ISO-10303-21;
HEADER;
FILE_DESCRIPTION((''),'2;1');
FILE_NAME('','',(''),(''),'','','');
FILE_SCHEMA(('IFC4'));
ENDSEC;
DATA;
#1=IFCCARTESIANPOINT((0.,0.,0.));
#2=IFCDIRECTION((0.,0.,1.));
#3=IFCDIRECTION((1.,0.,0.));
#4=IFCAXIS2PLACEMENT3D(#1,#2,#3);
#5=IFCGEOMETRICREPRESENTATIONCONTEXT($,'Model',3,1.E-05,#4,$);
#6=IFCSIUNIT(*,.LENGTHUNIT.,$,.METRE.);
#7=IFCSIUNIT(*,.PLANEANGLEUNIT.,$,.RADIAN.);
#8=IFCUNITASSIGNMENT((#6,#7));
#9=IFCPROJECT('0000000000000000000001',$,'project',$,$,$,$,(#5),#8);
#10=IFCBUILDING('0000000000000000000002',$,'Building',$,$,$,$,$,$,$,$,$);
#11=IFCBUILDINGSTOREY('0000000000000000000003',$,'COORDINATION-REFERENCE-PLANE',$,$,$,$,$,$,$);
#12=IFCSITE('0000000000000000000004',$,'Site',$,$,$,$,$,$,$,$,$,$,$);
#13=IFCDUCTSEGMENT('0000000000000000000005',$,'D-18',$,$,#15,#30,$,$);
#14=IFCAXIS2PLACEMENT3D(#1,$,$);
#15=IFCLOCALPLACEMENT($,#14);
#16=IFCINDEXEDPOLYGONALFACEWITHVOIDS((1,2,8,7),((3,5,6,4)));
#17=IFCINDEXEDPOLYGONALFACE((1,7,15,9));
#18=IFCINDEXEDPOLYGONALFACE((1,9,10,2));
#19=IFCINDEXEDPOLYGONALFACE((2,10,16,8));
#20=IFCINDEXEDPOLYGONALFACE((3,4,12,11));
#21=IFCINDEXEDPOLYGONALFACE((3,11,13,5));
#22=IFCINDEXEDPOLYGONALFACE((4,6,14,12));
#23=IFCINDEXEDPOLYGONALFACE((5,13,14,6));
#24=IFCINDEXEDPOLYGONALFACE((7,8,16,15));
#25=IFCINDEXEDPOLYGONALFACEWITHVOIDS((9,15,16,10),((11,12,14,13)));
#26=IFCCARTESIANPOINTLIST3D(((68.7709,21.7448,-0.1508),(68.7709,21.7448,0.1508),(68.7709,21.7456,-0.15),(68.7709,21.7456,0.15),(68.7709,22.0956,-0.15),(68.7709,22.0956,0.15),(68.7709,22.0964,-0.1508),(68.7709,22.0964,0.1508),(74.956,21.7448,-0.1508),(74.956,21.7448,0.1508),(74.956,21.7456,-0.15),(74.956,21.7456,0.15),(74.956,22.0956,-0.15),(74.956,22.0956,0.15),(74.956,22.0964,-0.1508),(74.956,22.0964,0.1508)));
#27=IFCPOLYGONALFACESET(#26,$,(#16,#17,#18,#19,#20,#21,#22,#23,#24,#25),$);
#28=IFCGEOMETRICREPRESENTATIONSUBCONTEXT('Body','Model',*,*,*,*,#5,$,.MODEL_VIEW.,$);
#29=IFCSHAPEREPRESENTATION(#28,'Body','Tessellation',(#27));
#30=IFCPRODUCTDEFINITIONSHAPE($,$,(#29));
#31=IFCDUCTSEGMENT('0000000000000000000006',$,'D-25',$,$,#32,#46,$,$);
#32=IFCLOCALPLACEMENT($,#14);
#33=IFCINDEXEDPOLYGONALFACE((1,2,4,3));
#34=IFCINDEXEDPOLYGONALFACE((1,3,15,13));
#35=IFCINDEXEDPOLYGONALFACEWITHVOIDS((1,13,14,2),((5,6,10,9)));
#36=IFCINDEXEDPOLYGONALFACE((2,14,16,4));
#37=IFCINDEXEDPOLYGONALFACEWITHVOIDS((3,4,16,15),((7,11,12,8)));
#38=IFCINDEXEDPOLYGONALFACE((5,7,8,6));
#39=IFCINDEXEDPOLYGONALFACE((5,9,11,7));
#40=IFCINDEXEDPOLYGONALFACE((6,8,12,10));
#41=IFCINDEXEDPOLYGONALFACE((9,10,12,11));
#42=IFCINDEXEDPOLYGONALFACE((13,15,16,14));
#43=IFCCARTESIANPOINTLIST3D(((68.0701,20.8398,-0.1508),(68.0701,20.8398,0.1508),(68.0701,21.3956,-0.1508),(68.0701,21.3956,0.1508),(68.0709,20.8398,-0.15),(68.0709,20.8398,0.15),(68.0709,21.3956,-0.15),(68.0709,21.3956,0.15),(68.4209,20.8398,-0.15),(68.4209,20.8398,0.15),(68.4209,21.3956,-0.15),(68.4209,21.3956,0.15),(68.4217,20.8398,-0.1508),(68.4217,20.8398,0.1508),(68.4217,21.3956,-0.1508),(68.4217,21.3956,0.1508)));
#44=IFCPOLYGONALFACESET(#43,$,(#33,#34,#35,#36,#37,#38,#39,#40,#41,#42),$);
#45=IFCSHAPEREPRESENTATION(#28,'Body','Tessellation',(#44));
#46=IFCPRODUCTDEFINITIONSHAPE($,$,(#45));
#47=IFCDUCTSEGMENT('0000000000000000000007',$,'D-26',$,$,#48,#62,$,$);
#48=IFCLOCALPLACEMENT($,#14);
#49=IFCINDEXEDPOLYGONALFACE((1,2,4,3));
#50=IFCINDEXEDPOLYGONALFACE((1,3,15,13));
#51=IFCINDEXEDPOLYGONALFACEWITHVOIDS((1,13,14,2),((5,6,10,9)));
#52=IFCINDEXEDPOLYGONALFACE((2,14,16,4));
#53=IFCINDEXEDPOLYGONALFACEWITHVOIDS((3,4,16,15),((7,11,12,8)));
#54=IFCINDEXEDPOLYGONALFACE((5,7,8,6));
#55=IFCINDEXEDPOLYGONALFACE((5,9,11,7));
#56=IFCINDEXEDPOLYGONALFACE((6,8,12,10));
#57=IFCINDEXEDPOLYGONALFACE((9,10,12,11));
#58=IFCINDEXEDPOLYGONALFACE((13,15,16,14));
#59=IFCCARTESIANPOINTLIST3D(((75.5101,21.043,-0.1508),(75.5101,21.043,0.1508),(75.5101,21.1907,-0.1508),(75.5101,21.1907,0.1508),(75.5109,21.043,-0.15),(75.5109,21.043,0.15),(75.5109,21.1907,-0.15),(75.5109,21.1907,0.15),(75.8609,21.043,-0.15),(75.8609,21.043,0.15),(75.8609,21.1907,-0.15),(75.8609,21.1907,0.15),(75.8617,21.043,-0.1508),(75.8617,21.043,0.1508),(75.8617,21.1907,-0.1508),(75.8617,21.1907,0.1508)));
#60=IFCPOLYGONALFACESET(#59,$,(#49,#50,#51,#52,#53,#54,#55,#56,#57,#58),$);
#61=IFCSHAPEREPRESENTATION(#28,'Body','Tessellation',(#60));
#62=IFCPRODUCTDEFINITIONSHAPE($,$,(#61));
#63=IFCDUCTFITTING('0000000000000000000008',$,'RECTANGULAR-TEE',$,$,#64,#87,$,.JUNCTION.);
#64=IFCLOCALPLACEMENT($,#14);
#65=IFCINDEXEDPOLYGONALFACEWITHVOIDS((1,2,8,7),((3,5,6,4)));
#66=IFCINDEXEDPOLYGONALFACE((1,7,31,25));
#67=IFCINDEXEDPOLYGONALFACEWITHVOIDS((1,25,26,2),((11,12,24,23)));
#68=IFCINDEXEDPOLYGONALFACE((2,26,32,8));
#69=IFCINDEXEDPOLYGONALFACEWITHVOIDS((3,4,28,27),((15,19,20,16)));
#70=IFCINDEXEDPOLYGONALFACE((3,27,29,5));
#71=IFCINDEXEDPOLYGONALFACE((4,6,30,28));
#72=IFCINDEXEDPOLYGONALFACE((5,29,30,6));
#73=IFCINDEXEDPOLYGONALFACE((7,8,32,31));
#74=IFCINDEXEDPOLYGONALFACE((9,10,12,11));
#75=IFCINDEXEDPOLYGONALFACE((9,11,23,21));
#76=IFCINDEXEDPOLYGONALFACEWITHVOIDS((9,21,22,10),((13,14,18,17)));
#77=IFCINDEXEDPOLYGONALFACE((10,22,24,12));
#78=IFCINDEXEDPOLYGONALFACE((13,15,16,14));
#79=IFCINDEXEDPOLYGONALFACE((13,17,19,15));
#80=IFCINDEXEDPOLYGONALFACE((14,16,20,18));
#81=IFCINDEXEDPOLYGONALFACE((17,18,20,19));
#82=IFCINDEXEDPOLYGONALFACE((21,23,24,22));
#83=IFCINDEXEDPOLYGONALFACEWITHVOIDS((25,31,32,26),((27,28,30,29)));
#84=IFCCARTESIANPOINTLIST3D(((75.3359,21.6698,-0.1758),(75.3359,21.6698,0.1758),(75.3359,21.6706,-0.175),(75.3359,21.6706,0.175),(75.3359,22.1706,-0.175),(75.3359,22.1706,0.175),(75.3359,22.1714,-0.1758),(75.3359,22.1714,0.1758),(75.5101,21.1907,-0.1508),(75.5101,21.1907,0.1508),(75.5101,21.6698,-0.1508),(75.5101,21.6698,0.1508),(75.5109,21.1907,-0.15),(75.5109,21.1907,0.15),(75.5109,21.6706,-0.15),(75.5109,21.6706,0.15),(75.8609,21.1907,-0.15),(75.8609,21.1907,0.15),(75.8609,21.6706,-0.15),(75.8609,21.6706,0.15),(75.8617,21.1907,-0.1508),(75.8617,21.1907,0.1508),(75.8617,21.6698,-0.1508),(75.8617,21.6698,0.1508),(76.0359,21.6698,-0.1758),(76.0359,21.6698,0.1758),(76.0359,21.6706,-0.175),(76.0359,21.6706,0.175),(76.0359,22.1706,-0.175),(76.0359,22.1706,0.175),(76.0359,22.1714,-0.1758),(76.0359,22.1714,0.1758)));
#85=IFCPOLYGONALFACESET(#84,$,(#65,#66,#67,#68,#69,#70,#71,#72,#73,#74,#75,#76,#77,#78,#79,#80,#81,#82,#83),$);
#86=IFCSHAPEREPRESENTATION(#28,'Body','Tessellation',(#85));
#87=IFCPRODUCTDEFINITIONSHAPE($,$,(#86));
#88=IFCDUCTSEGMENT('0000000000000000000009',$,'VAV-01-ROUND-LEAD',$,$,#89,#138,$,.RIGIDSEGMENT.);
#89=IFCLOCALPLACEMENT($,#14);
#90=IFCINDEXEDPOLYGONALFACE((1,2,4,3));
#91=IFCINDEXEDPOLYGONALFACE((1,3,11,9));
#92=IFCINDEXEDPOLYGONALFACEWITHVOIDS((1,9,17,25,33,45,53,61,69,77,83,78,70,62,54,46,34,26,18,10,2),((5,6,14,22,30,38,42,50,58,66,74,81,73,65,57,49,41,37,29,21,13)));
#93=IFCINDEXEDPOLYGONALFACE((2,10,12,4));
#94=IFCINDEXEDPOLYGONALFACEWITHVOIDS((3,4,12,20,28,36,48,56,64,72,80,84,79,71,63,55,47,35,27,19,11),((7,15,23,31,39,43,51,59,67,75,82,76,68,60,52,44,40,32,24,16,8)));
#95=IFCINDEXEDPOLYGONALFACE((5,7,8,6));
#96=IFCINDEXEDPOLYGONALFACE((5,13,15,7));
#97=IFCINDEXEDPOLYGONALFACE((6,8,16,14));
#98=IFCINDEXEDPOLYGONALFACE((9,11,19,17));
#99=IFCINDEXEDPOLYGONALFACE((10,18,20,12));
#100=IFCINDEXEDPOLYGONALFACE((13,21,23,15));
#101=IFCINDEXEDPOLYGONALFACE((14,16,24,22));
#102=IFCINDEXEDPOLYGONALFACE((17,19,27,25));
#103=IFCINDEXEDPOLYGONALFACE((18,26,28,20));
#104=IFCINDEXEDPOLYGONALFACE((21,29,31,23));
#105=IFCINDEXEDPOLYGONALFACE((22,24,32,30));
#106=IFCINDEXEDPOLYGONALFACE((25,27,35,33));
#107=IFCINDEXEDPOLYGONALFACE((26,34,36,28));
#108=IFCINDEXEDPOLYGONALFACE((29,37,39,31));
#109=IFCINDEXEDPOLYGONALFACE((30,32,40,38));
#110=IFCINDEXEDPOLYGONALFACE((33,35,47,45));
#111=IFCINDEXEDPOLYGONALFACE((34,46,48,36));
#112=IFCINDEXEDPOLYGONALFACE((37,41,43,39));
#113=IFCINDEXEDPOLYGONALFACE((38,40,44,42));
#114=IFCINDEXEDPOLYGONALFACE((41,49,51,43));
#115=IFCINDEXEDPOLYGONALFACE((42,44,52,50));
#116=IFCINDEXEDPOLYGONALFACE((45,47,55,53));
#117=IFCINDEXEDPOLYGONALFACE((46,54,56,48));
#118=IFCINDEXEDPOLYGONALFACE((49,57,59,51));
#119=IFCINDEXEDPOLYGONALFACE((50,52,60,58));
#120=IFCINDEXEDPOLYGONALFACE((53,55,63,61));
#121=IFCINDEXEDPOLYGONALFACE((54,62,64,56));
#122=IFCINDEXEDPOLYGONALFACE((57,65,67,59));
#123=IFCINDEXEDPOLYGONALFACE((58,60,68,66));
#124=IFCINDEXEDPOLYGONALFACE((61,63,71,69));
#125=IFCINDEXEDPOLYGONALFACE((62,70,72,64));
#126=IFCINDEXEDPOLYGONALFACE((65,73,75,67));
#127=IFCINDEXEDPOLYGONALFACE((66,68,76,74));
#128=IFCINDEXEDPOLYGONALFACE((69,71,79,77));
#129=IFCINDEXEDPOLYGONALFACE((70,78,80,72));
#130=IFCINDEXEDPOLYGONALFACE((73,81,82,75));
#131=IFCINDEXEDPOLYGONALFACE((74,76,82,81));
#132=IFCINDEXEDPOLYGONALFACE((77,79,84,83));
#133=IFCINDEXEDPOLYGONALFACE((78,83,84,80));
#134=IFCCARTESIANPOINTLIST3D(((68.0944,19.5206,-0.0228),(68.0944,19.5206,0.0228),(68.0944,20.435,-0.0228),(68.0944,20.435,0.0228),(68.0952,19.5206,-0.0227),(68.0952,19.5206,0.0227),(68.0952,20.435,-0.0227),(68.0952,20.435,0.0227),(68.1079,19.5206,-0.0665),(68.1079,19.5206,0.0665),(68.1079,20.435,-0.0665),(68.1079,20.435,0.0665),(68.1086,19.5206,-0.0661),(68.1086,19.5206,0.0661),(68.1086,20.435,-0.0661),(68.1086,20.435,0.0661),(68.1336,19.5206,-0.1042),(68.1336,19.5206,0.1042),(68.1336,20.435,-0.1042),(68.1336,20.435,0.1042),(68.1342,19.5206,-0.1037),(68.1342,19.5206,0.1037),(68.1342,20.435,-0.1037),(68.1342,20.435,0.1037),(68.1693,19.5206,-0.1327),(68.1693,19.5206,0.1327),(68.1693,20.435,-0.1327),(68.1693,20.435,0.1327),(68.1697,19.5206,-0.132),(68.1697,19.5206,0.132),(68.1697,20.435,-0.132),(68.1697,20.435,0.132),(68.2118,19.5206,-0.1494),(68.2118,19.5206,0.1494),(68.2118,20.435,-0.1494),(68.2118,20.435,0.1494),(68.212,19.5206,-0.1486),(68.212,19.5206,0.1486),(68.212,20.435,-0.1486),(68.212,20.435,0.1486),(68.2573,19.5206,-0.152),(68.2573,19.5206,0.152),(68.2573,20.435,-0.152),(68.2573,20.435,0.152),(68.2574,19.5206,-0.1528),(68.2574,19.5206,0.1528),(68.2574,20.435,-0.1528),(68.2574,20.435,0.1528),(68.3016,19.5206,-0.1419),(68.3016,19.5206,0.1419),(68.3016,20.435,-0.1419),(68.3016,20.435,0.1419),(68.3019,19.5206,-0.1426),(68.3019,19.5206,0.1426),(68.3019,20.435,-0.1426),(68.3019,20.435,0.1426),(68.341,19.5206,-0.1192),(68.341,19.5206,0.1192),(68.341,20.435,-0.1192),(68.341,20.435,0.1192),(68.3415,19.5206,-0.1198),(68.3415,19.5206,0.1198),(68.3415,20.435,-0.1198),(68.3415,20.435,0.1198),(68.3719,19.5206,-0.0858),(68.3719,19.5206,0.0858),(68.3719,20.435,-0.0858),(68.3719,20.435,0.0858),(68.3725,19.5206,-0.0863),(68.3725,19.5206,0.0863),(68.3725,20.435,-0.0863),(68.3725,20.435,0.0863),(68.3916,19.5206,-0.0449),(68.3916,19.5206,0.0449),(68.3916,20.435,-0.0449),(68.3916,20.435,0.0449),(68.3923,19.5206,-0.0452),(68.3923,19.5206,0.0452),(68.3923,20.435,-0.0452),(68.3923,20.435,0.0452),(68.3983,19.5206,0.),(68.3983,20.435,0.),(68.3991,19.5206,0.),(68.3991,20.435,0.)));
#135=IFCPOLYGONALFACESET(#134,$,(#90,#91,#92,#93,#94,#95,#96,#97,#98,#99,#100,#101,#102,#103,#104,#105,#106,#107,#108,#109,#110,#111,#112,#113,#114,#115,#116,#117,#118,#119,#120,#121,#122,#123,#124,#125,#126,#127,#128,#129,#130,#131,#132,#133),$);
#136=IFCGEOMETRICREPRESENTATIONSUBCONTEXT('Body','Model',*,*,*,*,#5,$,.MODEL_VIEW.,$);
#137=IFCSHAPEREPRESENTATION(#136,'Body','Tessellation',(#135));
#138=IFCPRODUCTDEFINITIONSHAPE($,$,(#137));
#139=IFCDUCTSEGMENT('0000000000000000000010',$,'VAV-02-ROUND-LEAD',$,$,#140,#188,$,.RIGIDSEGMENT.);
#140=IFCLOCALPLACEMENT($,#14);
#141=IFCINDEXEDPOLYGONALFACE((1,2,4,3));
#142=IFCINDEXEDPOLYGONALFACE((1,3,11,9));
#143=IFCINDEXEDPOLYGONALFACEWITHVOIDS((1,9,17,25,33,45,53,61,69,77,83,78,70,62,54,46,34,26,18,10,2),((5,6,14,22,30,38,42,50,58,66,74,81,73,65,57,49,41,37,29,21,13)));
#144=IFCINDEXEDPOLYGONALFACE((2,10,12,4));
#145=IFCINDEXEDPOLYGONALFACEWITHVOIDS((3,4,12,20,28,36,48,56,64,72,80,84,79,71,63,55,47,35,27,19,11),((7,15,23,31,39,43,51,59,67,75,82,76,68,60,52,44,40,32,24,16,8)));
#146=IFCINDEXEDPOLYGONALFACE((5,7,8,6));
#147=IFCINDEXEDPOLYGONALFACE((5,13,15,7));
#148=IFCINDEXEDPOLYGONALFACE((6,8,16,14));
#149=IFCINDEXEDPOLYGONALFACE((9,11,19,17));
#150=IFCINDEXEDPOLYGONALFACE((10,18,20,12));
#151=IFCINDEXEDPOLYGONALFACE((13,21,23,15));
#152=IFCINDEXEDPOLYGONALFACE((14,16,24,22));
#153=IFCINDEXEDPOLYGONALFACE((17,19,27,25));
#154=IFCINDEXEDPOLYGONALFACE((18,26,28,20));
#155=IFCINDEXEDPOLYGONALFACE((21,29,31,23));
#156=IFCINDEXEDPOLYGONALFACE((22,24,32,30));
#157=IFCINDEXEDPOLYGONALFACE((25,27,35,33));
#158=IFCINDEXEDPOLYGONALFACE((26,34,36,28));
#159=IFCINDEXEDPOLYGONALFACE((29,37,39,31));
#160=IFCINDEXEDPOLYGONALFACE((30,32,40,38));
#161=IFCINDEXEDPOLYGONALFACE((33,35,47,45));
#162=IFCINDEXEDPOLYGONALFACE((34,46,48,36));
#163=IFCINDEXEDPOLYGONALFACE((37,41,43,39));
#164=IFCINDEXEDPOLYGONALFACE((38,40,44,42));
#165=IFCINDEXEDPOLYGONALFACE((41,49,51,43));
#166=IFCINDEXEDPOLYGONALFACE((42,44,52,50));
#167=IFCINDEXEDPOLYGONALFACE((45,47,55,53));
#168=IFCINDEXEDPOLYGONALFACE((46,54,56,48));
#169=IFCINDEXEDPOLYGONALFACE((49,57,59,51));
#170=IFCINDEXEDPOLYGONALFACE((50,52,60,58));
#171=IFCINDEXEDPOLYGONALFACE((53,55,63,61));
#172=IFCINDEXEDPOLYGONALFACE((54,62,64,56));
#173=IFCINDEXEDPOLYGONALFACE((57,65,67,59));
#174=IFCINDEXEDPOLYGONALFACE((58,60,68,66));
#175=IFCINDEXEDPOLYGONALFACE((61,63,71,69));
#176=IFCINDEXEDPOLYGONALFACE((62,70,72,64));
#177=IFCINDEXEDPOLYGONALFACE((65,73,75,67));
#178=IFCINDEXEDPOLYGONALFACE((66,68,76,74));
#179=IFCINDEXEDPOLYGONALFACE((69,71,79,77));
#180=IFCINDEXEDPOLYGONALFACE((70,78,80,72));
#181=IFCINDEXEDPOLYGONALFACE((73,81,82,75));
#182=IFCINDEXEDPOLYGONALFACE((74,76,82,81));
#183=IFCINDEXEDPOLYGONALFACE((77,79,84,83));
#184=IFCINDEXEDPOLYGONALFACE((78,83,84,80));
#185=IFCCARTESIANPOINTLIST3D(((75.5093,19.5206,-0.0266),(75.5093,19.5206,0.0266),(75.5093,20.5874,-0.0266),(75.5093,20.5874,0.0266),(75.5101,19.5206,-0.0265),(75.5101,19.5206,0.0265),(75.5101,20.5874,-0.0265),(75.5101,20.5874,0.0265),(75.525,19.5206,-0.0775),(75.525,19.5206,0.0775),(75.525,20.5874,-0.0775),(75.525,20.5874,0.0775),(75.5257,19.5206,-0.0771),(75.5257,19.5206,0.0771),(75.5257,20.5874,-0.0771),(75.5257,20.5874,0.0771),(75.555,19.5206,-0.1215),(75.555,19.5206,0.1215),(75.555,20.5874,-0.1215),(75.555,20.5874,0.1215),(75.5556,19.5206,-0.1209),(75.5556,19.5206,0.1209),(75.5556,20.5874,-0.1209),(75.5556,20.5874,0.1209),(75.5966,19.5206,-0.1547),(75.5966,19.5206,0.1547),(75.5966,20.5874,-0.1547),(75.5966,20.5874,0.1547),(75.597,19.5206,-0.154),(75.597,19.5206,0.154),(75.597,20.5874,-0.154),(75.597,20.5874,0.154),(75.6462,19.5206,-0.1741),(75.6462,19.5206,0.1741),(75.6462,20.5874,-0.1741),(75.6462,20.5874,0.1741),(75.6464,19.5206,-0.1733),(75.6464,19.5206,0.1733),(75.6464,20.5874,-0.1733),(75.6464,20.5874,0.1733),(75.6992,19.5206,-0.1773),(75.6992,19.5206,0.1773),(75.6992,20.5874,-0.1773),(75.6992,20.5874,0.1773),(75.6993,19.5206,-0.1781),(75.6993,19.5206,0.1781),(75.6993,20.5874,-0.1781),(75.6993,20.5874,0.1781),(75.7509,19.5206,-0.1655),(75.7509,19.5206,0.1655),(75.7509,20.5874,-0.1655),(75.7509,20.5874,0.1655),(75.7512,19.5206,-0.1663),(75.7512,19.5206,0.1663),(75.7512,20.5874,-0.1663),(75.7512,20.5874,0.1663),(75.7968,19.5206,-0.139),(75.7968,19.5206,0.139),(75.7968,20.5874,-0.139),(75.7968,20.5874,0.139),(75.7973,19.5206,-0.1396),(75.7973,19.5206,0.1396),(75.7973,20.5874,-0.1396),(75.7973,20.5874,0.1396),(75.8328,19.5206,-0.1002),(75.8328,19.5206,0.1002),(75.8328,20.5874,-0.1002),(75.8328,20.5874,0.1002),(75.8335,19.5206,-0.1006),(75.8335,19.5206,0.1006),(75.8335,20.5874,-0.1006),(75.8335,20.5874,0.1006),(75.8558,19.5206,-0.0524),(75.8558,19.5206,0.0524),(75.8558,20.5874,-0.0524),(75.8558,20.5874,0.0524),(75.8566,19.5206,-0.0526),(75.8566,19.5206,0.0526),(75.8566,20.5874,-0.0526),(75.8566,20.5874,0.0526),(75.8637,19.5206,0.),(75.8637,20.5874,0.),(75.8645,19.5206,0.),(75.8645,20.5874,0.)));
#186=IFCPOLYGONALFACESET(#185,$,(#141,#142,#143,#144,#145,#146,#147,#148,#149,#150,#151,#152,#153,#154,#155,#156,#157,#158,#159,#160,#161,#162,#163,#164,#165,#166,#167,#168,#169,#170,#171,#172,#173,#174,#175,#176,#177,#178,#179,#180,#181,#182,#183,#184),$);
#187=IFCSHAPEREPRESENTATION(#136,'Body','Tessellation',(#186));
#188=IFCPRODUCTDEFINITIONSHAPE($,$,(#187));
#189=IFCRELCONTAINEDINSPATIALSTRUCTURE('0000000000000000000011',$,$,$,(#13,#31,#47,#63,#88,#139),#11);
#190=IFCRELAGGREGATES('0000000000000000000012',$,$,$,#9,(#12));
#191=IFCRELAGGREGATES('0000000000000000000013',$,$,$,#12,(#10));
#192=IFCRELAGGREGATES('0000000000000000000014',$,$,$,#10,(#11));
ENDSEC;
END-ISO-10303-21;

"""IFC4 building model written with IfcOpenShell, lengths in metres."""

from ifc_helpers import new_model, si_unit, frame, origin, origin_with_axes, place, context, subcontext, project, spatial, rectangle, hollow_rectangle, hollow_circle, extrude, boolean, element, save


model = new_model("IFC4")

# Units and contexts
model_context = context("Model", 3, precision=1e-05, world=origin_with_axes())
body_context_1 = subcontext(model_context, "Body", "Model", "MODEL_VIEW")
body_context_2 = subcontext(model_context, "Body", "Model", "MODEL_VIEW")
ifc_project = project(units=[si_unit("LENGTHUNIT", "METRE"), si_unit("PLANEANGLEUNIT", "RADIAN")], contexts=[model_context])

# Site, building, storey
site = spatial("IfcSite", under=ifc_project, Name="Site")
building = spatial("IfcBuilding", under=site, Name="Building")
storey = spatial("IfcBuildingStorey", under=building, Name="COORDINATION-REFERENCE-PLANE")

# Duct segments
duct_segment_1_placement = place(None, frame((68.7709, 21.9206, 0.0), z_axis=(1.0, 0.0, 0.0), x_axis=(0.0, 1.0, 0.0)))
element("IfcDuctSegment", 1, at=duct_segment_1_placement, inside=storey, Name="D-18", context=body_context_1, shape_type="SweptSolid", body=[
    extrude(hollow_rectangle(XDim=0.3516, YDim=0.3016, WallThickness=0.0008), origin(), (0.0, 0.0, 1.0), 6.1851),
])
duct_segment_2_placement = place(None, frame((68.2459, 20.8398, 0.0), z_axis=(0.0, 1.0, 0.0), x_axis=(1.0, 0.0, 0.0)))
element("IfcDuctSegment", 2, at=duct_segment_2_placement, inside=storey, Name="D-25", context=body_context_1, shape_type="SweptSolid", body=[
    extrude(hollow_rectangle(XDim=0.3516, YDim=0.3016, WallThickness=0.0008), origin(), (0.0, 0.0, 1.0), 0.5558),
])
duct_segment_3_placement = place(None, frame((75.6859, 21.043, 0.0), z_axis=(0.0, 1.0, 0.0), x_axis=(1.0, 0.0, 0.0)))
element("IfcDuctSegment", 3, at=duct_segment_3_placement, inside=storey, Name="D-26", context=body_context_1, shape_type="SweptSolid", body=[
    extrude(hollow_rectangle(XDim=0.3516, YDim=0.3016, WallThickness=0.0008), origin(), (0.0, 0.0, 1.0), 0.1477),
])

# Duct fitting
duct_fitting_1_placement = place(None, frame((75.6859, 21.9206, 0.0), z_axis=(-1.0, 0.0, 0.0), x_axis=(0.0, -1.0, 0.0)))
solid = boolean("UNION", extrude(rectangle(XDim=0.5, YDim=0.35), frame((0.0, 0.0, -0.35), z_axis=(0.0, 0.0, 1.0), x_axis=(1.0, 0.0, 0.0)), (0.0, 0.0, 1.0), 0.7), extrude(rectangle(XDim=0.35, YDim=0.3), frame((0.0, 0.0, 0.0), z_axis=(1.0, 0.0, 0.0), x_axis=(0.0, 0.0, -1.0)), (0.0, 0.0, 1.0), 0.7299))
element("IfcDuctFitting", 4, at=duct_fitting_1_placement, inside=storey, Name="RECTANGULAR-TEE", PredefinedType="JUNCTION", context=body_context_1, shape_type="CSG", body=[
    boolean("DIFFERENCE", boolean("UNION", extrude(rectangle(XDim=0.5016, YDim=0.3516), frame((0.0, 0.0, -0.35), z_axis=(0.0, 0.0, 1.0), x_axis=(1.0, 0.0, 0.0)), (0.0, 0.0, 1.0), 0.7), extrude(rectangle(XDim=0.3516, YDim=0.3016), frame((0.0, 0.0, 0.0), z_axis=(1.0, 0.0, 0.0), x_axis=(0.0, 0.0, -1.0)), (0.0, 0.0, 1.0), 0.7299)), solid),
])

# Duct segments
duct_segment_4_placement = place(None, frame((68.2459, 20.435, 0.0), z_axis=(0.0, -1.0, 0.0), x_axis=(1.0, 0.0, 0.0)))
element("IfcDuctSegment", 5, at=duct_segment_4_placement, inside=storey, Name="VAV-01-ROUND-LEAD", PredefinedType="RIGIDSEGMENT", context=body_context_2, shape_type="SweptSolid", body=[
    extrude(hollow_circle(Radius=0.1532, WallThickness=0.0008), origin(), (0.0, 0.0, 1.0), 0.9144),
])
for number, where, z_axis, x_axis, name in (
    (6, (75.6859, 20.5874, 0.0), (0.0, -1.0, 0.0), (1.0, 0.0, 0.0), "VAV-02-ROUND-LEAD"),
):
    element("IfcDuctSegment", number, at=place(None, frame(where, z_axis=z_axis, x_axis=x_axis)), inside=storey, Name=name, PredefinedType="RIGIDSEGMENT", context=body_context_2, shape_type="SweptSolid", body=[
        extrude(hollow_circle(Radius=0.1786, WallThickness=0.0008), origin(), (0.0, 0.0, 1.0), 1.0668),
    ])

save(model, "model.ifc")
